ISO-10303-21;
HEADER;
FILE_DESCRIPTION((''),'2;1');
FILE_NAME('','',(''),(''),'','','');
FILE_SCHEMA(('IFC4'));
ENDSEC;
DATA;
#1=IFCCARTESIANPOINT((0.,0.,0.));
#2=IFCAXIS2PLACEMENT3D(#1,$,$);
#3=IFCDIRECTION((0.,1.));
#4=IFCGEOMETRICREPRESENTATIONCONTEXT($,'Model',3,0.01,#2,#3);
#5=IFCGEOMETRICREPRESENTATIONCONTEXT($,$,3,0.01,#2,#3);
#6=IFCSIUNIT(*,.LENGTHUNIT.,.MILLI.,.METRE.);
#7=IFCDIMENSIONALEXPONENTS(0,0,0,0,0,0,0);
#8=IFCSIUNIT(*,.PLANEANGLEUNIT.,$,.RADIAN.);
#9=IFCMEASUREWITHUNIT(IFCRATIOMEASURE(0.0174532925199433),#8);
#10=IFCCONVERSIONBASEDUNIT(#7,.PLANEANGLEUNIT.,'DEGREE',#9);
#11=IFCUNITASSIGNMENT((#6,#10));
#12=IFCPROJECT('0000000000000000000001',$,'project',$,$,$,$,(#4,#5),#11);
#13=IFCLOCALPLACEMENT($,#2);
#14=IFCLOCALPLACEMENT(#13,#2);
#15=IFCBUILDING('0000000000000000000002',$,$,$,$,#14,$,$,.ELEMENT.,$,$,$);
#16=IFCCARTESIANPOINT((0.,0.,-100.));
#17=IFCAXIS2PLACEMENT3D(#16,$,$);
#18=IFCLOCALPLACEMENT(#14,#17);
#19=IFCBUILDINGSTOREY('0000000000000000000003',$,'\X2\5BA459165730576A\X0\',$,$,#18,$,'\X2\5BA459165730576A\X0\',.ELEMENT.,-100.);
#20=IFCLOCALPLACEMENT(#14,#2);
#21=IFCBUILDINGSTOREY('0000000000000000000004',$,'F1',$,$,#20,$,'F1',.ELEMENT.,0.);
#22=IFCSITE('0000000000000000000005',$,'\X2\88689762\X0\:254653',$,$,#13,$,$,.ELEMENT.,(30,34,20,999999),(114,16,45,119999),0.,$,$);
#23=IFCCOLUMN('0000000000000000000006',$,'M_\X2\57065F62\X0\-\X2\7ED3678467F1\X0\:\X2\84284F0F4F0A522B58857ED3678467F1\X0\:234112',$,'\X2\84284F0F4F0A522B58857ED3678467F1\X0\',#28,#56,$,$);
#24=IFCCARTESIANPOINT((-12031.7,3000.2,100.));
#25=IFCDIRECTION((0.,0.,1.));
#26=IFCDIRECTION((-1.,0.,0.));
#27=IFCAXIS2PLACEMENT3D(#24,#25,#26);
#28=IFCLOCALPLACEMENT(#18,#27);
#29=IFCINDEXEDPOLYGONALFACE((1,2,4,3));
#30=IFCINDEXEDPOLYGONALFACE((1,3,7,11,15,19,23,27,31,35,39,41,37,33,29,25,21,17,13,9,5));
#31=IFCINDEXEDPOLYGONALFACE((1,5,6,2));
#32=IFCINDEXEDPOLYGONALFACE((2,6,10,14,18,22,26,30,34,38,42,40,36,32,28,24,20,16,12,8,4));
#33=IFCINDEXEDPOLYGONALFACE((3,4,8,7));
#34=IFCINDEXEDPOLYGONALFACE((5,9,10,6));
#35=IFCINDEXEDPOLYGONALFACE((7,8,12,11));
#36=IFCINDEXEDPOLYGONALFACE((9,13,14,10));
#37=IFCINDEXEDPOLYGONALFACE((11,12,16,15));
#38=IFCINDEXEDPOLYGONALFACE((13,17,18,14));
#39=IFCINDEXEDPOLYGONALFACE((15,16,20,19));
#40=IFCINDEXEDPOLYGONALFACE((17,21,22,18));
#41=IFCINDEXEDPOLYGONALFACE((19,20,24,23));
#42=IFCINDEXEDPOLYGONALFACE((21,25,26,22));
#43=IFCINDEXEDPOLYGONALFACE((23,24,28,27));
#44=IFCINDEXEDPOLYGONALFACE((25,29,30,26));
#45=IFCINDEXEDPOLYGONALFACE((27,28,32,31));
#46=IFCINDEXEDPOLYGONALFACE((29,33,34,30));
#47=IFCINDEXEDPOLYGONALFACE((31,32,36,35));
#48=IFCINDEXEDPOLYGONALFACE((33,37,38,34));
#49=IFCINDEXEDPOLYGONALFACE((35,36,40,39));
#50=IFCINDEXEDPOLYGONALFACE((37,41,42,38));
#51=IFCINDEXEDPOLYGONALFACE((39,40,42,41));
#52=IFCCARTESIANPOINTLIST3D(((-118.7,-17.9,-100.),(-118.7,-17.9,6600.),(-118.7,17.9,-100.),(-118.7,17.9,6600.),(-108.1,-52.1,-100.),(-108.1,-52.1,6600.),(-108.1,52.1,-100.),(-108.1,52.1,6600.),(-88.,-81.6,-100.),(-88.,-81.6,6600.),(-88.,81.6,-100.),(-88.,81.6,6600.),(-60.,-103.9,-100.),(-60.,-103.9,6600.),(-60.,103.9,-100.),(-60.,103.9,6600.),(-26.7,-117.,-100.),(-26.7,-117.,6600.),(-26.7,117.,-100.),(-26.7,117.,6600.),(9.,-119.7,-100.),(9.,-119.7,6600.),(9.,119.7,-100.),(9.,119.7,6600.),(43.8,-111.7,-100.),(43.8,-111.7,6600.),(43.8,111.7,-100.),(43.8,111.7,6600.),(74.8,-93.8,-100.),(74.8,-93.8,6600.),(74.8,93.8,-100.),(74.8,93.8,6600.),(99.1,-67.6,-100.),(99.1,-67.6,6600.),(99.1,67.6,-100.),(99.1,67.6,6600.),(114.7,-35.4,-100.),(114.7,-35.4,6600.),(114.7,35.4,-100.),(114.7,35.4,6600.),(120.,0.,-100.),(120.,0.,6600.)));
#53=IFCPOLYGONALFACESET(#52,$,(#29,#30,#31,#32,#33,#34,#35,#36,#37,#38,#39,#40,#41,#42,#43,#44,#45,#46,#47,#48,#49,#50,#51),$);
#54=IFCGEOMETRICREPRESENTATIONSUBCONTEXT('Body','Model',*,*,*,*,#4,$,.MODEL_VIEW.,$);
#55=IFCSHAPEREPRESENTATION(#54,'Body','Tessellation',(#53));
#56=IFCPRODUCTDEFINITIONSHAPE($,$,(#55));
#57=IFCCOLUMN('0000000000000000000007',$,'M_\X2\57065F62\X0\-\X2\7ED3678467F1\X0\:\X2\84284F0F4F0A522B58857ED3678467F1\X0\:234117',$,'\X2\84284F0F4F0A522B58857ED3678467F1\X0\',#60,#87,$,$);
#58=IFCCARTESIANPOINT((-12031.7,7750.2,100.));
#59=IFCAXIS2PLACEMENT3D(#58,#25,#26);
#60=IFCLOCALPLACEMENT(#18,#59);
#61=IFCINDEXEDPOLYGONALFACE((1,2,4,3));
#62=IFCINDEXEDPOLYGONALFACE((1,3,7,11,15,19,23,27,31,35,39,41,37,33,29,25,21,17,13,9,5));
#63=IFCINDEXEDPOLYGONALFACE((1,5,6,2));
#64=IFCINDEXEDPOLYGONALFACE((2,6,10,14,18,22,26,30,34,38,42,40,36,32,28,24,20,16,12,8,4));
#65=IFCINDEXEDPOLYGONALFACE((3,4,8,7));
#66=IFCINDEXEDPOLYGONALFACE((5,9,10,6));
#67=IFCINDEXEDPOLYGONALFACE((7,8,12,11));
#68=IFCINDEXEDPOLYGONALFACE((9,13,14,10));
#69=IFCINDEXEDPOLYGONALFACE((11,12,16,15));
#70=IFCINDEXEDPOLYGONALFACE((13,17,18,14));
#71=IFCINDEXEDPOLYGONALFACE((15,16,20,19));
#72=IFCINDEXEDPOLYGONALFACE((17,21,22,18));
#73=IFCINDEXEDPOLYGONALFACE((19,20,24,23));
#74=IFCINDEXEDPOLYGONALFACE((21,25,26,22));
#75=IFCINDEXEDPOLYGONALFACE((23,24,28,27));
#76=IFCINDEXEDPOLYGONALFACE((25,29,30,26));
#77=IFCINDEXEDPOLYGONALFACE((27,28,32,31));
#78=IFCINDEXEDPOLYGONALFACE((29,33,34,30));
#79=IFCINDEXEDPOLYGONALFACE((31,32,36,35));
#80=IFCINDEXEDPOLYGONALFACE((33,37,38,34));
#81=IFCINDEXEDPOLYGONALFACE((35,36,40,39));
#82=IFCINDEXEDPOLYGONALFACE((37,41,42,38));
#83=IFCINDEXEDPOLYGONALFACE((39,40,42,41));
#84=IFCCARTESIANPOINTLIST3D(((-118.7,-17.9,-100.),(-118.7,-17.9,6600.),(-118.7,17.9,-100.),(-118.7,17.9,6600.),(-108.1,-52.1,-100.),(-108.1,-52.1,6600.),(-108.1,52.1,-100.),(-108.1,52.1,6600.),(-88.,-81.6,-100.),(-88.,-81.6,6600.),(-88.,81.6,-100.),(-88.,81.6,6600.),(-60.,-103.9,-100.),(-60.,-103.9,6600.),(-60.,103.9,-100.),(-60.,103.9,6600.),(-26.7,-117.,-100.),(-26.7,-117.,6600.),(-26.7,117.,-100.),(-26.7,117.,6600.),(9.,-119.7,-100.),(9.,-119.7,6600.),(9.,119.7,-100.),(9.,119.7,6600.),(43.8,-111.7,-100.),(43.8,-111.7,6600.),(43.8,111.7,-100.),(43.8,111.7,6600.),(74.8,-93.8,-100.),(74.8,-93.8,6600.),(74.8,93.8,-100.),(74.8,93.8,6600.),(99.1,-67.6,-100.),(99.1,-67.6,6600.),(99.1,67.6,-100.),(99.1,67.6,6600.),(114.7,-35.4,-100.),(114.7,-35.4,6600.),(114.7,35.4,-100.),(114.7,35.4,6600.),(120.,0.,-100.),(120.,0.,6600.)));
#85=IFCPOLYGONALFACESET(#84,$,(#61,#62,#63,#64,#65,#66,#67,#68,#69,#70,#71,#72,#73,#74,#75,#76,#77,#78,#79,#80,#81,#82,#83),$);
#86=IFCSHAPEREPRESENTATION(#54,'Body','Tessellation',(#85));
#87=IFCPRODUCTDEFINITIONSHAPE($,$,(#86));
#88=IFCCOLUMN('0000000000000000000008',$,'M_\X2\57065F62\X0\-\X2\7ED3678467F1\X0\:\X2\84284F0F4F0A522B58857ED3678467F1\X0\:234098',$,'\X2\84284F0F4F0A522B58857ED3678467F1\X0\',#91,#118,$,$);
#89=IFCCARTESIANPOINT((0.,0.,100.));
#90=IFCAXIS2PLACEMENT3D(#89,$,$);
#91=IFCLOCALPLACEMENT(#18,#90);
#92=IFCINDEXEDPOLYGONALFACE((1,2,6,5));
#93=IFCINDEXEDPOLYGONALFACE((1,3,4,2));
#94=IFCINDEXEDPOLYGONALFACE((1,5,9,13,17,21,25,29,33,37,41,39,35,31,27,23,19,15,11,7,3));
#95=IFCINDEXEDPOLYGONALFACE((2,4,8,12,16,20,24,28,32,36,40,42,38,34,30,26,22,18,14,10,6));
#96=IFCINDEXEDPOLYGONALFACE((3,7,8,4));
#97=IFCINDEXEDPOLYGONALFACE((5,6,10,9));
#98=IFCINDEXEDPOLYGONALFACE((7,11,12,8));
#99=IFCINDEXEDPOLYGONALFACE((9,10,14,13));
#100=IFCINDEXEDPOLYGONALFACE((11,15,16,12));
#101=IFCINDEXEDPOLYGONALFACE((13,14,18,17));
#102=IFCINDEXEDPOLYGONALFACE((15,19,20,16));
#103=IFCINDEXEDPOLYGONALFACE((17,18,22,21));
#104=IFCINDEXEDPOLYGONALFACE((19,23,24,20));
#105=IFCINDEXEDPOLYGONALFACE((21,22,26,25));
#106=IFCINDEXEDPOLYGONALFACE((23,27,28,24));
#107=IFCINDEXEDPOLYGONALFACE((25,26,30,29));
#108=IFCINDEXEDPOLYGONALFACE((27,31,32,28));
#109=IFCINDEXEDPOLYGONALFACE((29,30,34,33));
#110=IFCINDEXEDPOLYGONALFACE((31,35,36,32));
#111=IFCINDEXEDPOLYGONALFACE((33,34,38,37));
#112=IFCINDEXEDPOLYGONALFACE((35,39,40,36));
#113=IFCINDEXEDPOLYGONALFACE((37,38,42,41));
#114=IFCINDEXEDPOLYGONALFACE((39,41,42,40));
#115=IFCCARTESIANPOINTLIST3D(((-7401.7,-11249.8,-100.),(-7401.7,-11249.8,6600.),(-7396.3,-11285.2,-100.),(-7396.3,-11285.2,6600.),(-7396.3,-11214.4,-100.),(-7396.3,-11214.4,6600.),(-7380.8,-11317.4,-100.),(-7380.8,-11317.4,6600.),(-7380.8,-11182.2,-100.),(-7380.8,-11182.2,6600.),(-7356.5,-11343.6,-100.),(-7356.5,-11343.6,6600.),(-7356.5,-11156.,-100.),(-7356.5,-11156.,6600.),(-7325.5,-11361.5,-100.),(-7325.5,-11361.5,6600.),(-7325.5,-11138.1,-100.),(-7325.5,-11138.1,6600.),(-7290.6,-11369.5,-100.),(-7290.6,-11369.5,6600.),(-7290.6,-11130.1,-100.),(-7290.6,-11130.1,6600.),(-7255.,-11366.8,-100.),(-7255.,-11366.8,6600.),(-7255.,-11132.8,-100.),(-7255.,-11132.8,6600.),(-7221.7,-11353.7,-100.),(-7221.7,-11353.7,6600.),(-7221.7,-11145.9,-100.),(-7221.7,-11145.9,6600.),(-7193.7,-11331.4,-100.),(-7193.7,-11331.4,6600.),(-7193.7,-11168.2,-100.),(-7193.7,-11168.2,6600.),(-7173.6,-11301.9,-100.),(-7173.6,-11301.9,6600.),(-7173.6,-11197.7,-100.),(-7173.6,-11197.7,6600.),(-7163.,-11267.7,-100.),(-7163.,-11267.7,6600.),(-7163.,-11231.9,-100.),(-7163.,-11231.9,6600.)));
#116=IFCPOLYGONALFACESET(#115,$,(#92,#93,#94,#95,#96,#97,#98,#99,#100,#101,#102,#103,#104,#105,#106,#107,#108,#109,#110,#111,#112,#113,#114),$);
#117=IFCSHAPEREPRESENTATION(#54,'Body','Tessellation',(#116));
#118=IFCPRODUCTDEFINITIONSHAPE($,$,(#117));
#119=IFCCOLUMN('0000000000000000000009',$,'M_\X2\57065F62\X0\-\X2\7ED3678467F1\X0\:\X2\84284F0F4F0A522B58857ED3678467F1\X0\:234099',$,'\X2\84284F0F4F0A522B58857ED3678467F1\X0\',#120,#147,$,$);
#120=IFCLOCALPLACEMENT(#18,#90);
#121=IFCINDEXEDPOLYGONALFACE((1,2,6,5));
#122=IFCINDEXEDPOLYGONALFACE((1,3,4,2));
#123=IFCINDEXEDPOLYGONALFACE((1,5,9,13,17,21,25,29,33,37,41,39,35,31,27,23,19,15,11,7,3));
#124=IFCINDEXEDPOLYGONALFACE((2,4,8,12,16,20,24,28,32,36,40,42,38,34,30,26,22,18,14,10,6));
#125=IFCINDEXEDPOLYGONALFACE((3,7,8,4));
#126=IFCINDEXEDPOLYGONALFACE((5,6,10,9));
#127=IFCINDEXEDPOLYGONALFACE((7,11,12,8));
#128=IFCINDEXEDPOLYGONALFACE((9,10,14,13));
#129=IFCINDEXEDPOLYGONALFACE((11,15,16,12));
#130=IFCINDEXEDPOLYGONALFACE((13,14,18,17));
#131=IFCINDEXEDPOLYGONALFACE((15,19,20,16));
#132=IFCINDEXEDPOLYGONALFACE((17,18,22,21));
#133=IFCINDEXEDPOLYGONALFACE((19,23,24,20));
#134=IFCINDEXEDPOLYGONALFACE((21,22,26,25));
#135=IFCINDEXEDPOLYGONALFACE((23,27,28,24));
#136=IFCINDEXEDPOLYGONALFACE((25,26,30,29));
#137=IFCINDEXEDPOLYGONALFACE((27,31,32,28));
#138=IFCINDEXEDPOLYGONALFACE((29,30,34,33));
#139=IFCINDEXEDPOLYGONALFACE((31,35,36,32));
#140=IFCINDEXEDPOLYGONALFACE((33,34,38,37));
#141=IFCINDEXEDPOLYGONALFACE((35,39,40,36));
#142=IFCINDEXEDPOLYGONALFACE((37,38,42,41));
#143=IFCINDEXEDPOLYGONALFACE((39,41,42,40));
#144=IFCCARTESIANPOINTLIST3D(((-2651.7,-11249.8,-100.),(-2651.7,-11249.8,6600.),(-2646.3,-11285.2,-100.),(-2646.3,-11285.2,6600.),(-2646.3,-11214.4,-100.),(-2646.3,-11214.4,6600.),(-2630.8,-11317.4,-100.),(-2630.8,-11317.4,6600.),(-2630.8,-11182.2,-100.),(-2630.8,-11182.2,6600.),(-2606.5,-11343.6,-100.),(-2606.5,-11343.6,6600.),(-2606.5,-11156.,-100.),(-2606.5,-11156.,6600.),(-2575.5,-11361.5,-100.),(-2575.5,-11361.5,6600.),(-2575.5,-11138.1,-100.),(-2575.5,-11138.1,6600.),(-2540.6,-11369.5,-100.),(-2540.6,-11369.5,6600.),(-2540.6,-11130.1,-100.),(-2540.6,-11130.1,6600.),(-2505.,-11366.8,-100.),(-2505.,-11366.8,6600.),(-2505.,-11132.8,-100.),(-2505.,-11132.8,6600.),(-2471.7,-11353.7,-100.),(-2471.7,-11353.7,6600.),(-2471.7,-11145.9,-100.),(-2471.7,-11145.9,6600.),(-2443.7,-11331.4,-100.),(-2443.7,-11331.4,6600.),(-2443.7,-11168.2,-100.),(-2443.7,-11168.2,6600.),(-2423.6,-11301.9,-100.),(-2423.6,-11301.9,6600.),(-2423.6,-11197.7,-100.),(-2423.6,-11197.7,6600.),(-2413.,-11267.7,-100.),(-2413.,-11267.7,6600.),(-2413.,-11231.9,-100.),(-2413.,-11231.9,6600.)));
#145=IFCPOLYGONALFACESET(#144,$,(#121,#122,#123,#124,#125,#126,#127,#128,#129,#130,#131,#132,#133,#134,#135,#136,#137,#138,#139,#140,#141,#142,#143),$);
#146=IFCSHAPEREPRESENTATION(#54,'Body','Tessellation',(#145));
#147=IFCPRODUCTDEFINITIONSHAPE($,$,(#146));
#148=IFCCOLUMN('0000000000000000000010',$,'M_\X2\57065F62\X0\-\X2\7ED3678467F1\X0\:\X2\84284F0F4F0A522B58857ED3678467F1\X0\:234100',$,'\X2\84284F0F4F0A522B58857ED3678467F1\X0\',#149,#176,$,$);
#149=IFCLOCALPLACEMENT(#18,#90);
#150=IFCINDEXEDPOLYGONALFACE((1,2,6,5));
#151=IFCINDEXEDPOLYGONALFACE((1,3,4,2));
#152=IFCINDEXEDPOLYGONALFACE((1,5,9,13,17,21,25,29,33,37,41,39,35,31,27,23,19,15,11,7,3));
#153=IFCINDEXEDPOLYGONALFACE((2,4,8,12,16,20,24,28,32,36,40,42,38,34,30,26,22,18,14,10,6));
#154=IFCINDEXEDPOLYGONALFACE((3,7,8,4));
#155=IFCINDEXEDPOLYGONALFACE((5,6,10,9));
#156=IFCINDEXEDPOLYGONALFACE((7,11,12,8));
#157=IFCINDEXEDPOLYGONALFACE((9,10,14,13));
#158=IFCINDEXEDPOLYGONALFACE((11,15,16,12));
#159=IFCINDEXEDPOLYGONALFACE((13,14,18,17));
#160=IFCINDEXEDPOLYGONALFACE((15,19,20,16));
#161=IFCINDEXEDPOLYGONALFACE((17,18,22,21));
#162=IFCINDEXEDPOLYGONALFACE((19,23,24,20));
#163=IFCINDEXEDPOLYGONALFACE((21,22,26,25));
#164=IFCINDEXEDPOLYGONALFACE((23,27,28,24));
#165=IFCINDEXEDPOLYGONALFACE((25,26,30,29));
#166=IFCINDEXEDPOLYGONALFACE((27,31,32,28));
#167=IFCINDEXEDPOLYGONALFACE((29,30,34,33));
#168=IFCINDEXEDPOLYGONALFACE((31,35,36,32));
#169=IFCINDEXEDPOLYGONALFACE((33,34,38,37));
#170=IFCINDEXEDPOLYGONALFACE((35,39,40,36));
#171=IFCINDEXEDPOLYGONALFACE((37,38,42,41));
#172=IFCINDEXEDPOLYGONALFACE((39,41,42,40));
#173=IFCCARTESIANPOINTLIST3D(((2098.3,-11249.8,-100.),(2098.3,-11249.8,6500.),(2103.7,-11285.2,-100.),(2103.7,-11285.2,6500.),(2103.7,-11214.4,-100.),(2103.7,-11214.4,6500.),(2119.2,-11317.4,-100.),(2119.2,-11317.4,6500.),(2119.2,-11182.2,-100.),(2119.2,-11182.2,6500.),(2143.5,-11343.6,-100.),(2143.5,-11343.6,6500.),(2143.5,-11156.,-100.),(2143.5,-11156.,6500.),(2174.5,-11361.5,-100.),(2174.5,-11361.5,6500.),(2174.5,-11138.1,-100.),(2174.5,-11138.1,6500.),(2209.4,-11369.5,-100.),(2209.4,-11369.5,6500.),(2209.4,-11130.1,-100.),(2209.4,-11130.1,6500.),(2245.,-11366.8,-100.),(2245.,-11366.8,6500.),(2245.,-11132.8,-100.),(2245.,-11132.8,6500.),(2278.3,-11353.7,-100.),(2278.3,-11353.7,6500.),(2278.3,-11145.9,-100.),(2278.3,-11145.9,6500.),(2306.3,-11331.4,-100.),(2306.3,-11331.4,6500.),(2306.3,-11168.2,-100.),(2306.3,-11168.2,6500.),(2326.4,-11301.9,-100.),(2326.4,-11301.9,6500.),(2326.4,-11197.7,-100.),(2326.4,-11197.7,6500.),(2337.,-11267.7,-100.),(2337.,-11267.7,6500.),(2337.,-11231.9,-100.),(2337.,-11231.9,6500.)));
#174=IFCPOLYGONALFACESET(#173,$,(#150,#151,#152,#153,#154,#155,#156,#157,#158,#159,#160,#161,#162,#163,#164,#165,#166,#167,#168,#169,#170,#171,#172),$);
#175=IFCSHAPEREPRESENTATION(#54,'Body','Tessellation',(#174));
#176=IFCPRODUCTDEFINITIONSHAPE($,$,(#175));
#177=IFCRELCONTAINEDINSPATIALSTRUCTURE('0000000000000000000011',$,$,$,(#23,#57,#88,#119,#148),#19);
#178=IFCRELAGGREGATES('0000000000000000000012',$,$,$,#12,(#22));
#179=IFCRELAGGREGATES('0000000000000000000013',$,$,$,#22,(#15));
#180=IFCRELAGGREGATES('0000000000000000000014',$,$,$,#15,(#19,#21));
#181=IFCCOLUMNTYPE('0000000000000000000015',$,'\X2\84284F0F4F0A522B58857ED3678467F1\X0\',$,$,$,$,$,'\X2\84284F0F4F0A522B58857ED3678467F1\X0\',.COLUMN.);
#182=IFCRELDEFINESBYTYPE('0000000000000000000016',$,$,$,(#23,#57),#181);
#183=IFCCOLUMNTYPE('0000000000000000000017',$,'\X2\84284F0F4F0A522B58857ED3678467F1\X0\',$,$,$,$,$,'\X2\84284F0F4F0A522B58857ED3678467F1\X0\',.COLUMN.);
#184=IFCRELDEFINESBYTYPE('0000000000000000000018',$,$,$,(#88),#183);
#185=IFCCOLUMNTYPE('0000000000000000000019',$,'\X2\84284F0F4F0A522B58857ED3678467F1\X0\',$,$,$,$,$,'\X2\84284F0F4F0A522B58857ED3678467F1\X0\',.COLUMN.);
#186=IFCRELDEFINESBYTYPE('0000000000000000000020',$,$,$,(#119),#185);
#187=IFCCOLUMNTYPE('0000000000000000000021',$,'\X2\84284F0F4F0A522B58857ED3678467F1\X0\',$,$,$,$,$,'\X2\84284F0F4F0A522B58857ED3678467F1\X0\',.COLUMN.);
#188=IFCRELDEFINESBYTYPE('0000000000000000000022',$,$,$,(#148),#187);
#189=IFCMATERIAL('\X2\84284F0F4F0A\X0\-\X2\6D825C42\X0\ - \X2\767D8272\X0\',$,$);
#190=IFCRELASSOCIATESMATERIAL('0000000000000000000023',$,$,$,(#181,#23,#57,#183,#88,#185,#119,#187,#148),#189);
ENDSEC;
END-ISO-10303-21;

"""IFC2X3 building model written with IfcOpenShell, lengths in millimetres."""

from ifc_helpers import new_model, entity, si_unit, converted_unit, direction, frame, frame_2d, origin, origin_2d_with_axis, place, context, subcontext, project, spatial, circle, extrude, source, transform, mapped, material, type_object, type_shapes, element, save


model = new_model("IFC2X3")

# Units and contexts
model_context = context("Model", 3, precision=0.01, world=origin(), true_north=direction((0.0, 1.0)))
context_of_model = context(None, 3, precision=0.01, world=origin(), true_north=direction((0.0, 1.0)))
body_context = subcontext(model_context, "Body", "Model", "MODEL_VIEW")
ifc_project = project(units=[si_unit("LENGTHUNIT", "METRE", prefix="MILLI"), converted_unit("PLANEANGLEUNIT", "DEGREE", entity("IfcRatioMeasure", 0.0174532925199433), si_unit("PLANEANGLEUNIT", "RADIAN"), dimensions=[0, 0, 0, 0, 0, 0, 0])], contexts=[model_context, context_of_model])

# Site, building, storey
site_placement = place(None, origin())
site = spatial("IfcSite", under=ifc_project, at=site_placement, Name="表面:254653", CompositionType="ELEMENT", RefLatitude=(30, 34, 20, 999999), RefLongitude=(114, 16, 45, 119999), RefElevation=0.0)
building_placement = place(site_placement, origin())
building = spatial("IfcBuilding", under=site, at=building_placement, CompositionType="ELEMENT")
storey_1_placement = place(building_placement, frame((0.0, 0.0, -100.0)))
storey_1 = spatial("IfcBuildingStorey", under=building, at=storey_1_placement, Name="室外地坪", LongName="室外地坪", CompositionType="ELEMENT", Elevation=-100.0)

# Columns
ifc_material_1 = material(Name="萨伏伊-涂层 - 白色")
column_type_1 = type_object("IfcColumnType", Name="萨伏伊别墅结构柱", ElementType="萨伏伊别墅结构柱", PredefinedType="COLUMN", material=ifc_material_1)
shared_shape_1 = source(origin(), body_context, "Body", "SweptSolid", [
    extrude(circle(Radius=120.0, at=frame_2d((0.0, 0.0), x_axis=(1.0, 0.0))), frame((0.0, 0.0, -100.0)), (0.0, 0.0, 1.0), 6700.0),
])
type_shapes(column_type_1, [shared_shape_1])
for number, where, z_axis, x_axis, name in (
    (1, (-12031.7, 3000.2, 100.0), (0.0, 0.0, 1.0), (-1.0, 0.0, 0.0), "M_圆形-结构柱:萨伏伊别墅结构柱:234112"),
    (2, (-12031.7, 7750.2, 100.0), (0.0, 0.0, 1.0), (-1.0, 0.0, 0.0), "M_圆形-结构柱:萨伏伊别墅结构柱:234117"),
):
    element("IfcColumn", number, at=place(storey_1_placement, frame(where, z_axis=z_axis, x_axis=x_axis)), inside=storey_1, type_object=column_type_1, material=ifc_material_1, Name=name, ObjectType="萨伏伊别墅结构柱", context=body_context, shape_type="MappedRepresentation", body=[
        mapped(shared_shape_1, transform((0.0, 0.0, 0.0), scale=1.0)),
    ])
column_type_2 = type_object("IfcColumnType", Name="萨伏伊别墅结构柱", ElementType="萨伏伊别墅结构柱", PredefinedType="COLUMN", material=ifc_material_1)
shared_shape_2 = source(origin(), body_context, "Body", "SweptSolid", [
    extrude(circle(Radius=120.0, at=origin_2d_with_axis()), frame((-7281.7, -11249.8, -100.0), z_axis=(0.0, 0.0, 1.0), x_axis=(-1.0, 0.0, 0.0)), (0.0, 0.0, 1.0), 6700.0),
])
type_shapes(column_type_2, [shared_shape_2])
column_1_placement = place(storey_1_placement, frame((0.0, 0.0, 100.0)))
element("IfcColumn", 3, at=column_1_placement, inside=storey_1, type_object=column_type_2, material=ifc_material_1, Name="M_圆形-结构柱:萨伏伊别墅结构柱:234098", ObjectType="萨伏伊别墅结构柱", context=body_context, shape_type="MappedRepresentation", body=[
    mapped(shared_shape_2, transform((0.0, 0.0, 0.0), scale=1.0)),
])
column_type_3 = type_object("IfcColumnType", Name="萨伏伊别墅结构柱", ElementType="萨伏伊别墅结构柱", PredefinedType="COLUMN", material=ifc_material_1)
shared_shape_3 = source(origin(), body_context, "Body", "SweptSolid", [
    extrude(circle(Radius=120.0, at=origin_2d_with_axis()), frame((-2531.7, -11249.8, -100.0), z_axis=(0.0, 0.0, 1.0), x_axis=(-1.0, 0.0, 0.0)), (0.0, 0.0, 1.0), 6700.0),
])
type_shapes(column_type_3, [shared_shape_3])
column_2_placement = place(storey_1_placement, frame((0.0, 0.0, 100.0)))
element("IfcColumn", 4, at=column_2_placement, inside=storey_1, type_object=column_type_3, material=ifc_material_1, Name="M_圆形-结构柱:萨伏伊别墅结构柱:234099", ObjectType="萨伏伊别墅结构柱", context=body_context, shape_type="MappedRepresentation", body=[
    mapped(shared_shape_3, transform((0.0, 0.0, 0.0), scale=1.0)),
])
column_type_4 = type_object("IfcColumnType", Name="萨伏伊别墅结构柱", ElementType="萨伏伊别墅结构柱", PredefinedType="COLUMN", material=ifc_material_1)
shared_shape_4 = source(origin(), body_context, "Body", "SweptSolid", [
    extrude(circle(Radius=120.0, at=origin_2d_with_axis()), frame((2218.3, -11249.8, -100.0), z_axis=(0.0, 0.0, 1.0), x_axis=(-1.0, 0.0, 0.0)), (0.0, 0.0, 1.0), 6600.0),
])
type_shapes(column_type_4, [shared_shape_4])
column_3_placement = place(storey_1_placement, frame((0.0, 0.0, 100.0)))
element("IfcColumn", 5, at=column_3_placement, inside=storey_1, type_object=column_type_4, material=ifc_material_1, Name="M_圆形-结构柱:萨伏伊别墅结构柱:234100", ObjectType="萨伏伊别墅结构柱", context=body_context, shape_type="MappedRepresentation", body=[
    mapped(shared_shape_4, transform((0.0, 0.0, 0.0), scale=1.0)),
])

# Shared definitions
storey_2_placement = place(building_placement, origin())
storey_2 = spatial("IfcBuildingStorey", under=building, at=storey_2_placement, Name="F1", LongName="F1", CompositionType="ELEMENT", Elevation=0.0)

save(model, "model.ifc")
